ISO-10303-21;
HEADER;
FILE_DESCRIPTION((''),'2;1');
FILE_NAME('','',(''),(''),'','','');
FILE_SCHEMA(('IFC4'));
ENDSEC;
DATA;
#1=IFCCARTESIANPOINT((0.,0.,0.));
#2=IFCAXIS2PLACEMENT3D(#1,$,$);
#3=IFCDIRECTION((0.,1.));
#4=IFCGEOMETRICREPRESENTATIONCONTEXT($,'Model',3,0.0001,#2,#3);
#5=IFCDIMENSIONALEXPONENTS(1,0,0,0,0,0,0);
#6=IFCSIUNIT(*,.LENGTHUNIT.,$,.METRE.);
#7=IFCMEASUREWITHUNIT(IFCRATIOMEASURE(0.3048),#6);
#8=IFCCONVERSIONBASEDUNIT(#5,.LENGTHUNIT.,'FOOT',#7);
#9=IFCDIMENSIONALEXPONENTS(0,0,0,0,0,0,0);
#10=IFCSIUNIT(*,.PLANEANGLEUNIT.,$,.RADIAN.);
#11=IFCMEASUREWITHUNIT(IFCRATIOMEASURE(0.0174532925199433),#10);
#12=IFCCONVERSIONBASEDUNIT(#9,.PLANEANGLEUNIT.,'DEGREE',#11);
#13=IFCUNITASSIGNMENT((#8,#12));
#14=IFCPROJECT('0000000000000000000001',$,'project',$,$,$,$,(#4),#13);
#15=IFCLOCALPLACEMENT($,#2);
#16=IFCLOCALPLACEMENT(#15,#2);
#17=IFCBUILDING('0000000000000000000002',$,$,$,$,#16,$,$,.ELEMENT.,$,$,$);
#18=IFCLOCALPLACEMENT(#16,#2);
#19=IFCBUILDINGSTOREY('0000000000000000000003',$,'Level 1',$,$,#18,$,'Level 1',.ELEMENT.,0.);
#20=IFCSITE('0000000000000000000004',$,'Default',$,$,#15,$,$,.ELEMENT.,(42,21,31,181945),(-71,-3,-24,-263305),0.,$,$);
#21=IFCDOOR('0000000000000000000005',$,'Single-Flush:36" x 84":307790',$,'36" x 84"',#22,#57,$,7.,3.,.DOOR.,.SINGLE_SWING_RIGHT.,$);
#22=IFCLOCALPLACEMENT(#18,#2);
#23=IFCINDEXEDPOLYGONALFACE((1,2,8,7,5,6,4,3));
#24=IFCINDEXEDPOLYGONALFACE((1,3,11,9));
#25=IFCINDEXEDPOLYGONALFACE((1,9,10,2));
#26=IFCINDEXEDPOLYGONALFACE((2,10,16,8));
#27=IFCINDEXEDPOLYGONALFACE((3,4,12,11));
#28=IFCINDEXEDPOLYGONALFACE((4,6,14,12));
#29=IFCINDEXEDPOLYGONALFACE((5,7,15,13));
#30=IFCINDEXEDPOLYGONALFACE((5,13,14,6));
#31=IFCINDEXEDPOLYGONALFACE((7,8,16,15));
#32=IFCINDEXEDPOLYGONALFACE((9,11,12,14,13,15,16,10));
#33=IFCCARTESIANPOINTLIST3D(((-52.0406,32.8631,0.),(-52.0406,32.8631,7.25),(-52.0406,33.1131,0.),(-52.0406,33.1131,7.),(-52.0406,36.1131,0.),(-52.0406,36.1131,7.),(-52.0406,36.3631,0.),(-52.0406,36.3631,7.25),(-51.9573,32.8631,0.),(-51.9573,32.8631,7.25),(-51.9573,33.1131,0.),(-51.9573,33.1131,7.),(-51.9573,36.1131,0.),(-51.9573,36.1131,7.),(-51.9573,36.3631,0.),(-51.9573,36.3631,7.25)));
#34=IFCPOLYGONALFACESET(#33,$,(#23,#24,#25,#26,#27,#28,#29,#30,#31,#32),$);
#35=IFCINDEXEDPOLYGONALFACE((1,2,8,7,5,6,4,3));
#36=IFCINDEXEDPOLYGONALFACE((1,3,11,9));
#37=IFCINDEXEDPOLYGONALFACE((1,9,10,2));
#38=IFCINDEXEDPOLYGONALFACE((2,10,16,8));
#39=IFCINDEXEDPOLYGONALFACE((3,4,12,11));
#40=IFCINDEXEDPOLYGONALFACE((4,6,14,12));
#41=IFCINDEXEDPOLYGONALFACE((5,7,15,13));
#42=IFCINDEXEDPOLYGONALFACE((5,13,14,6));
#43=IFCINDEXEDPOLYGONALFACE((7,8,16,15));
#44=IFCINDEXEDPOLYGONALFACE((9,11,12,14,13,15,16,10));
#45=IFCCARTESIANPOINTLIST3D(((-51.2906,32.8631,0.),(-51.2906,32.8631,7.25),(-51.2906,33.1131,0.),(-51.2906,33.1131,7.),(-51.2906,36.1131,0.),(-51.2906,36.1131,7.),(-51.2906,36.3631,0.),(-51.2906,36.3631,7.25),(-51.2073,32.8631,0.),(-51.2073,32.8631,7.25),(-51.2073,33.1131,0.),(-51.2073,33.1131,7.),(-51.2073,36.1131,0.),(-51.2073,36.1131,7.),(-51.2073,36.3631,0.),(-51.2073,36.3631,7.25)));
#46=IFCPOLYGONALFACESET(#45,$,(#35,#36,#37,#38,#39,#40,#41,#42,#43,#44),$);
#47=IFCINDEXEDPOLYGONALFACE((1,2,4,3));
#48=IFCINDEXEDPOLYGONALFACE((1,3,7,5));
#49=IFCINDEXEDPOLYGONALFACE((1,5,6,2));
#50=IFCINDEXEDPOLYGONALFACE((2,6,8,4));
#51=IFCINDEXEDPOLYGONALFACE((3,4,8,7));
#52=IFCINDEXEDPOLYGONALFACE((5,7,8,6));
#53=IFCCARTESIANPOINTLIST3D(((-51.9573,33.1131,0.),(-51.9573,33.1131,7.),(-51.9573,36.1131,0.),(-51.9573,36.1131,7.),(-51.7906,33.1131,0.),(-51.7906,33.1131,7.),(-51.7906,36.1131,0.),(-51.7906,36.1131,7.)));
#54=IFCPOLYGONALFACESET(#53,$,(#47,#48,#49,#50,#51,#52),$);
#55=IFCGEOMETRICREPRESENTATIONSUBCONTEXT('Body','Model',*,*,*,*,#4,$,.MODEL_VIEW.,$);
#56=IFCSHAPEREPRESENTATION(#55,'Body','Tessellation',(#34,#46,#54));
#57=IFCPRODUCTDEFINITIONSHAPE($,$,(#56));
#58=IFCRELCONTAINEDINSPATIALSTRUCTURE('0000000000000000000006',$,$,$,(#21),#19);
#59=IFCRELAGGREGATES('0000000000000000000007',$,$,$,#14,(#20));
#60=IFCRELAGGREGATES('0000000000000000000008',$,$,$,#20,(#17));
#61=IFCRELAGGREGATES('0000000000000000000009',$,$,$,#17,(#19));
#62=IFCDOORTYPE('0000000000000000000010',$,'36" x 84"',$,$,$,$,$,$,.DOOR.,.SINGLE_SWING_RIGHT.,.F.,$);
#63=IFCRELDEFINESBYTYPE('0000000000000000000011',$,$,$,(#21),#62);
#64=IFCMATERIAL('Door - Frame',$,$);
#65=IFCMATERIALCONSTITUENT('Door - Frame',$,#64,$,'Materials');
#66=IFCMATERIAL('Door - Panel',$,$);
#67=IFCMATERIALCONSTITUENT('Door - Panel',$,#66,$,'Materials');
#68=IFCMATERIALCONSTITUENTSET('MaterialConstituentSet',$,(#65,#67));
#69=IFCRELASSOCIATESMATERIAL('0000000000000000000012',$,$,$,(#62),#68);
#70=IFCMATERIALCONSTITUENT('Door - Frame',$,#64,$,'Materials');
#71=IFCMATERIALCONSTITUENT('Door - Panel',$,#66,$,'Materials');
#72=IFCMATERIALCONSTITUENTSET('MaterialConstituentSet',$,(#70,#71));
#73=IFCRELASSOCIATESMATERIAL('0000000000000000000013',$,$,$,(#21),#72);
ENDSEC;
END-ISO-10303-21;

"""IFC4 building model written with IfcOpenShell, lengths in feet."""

from ifc_helpers import new_model, entity, si_unit, converted_unit, direction, frame, frame_2d, origin, place, context, subcontext, project, spatial, polyline, rectangle, outline, extrude, source, transform, mapped, material, constituent, constituent_set, type_object, type_shapes, element, save


model = new_model("IFC4")

# Units and contexts
model_context = context("Model", 3, precision=0.0001, world=origin(), true_north=direction((0.0, 1.0)))
body_context = subcontext(model_context, "Body", "Model", "MODEL_VIEW")
ifc_project = project(units=[converted_unit("LENGTHUNIT", "FOOT", entity("IfcRatioMeasure", 0.3048), si_unit("LENGTHUNIT", "METRE"), dimensions=[1, 0, 0, 0, 0, 0, 0]), converted_unit("PLANEANGLEUNIT", "DEGREE", entity("IfcRatioMeasure", 0.0174532925199433), si_unit("PLANEANGLEUNIT", "RADIAN"), dimensions=[0, 0, 0, 0, 0, 0, 0])], contexts=[model_context])

# Site, building, storey
site_placement = place(None, origin())
site = spatial("IfcSite", under=ifc_project, at=site_placement, Name="Default", CompositionType="ELEMENT", RefLatitude=(42, 21, 31, 181945), RefLongitude=(-71, -3, -24, -263305), RefElevation=0.0)
building_placement = place(site_placement, origin())
building = spatial("IfcBuilding", under=site, at=building_placement, CompositionType="ELEMENT")
storey_placement = place(building_placement, origin())
storey = spatial("IfcBuildingStorey", under=building, at=storey_placement, Name="Level 1", LongName="Level 1", CompositionType="ELEMENT", Elevation=0.0)

# Shared definitions
placement_1 = place(storey_placement, frame((-51.6239, 66.9464, 0.0), z_axis=(0.0, 0.0, 1.0), x_axis=(0.0, -1.0, 0.0)))

# Door
ifc_material_1 = material(Name="Door - Frame")
ifc_constituent_1 = constituent(ifc_material_1, Name="Door - Frame", Category="Materials")
ifc_material_2 = material(Name="Door - Panel")
ifc_constituent_2 = constituent(ifc_material_2, Name="Door - Panel", Category="Materials")
ifc_constituent_set_1 = constituent_set(constituents=[ifc_constituent_1, ifc_constituent_2], Name="MaterialConstituentSet")
ifc_constituent_3 = constituent(ifc_material_1, Name="Door - Frame", Category="Materials")
ifc_constituent_4 = constituent(ifc_material_2, Name="Door - Panel", Category="Materials")
ifc_constituent_set_2 = constituent_set(constituents=[ifc_constituent_3, ifc_constituent_4], Name="MaterialConstituentSet")
door_type = type_object("IfcDoorType", Name="36\" x 84\"", OperationType="SINGLE_SWING_RIGHT", ParameterTakesPrecedence=False, PredefinedType="DOOR", material=ifc_constituent_set_2)
shared_shape = source(origin(), body_context, "Body", "SweptSolid", [
    extrude(outline(polyline([(-1.75, -3.6875), (1.75, -3.6875), (1.75, 3.5625), (1.5, 3.5625), (1.5, -3.4375), (-1.5, -3.4375), (-1.5, 3.5625), (-1.75, 3.5625), (-1.75, -3.6875)])), frame((1.5, 0.6667, 3.5625), z_axis=(0.0, 1.0, 0.0), x_axis=(1.0, 0.0, 0.0)), (0.0, 0.0, 1.0), 0.0833),
    extrude(outline(polyline([(-3.6875, -1.75), (3.5625, -1.75), (3.5625, -1.5), (-3.4375, -1.5), (-3.4375, 1.5), (3.5625, 1.5), (3.5625, 1.75), (-3.6875, 1.75), (-3.6875, -1.75)])), frame((1.5, -0.0833, 3.5625), z_axis=(0.0, 1.0, 0.0), x_axis=(0.0, 0.0, -1.0)), (0.0, 0.0, 1.0), 0.0833),
    extrude(rectangle(XDim=0.1667, YDim=3.0, at=frame_2d((0.0, 0.0), x_axis=(1.0, 0.0))), frame((1.5, 0.5833, 0.0), z_axis=(0.0, 0.0, 1.0), x_axis=(0.0, 1.0, 0.0)), (0.0, 0.0, 1.0), 7.0),
])
type_shapes(door_type, [shared_shape])
placement_2 = place(placement_1, frame((33.8333, 0.3333, 0.0)))
door_placement = place(placement_2, frame((0.0, 0.0, 0.0), z_axis=(0.0, 0.0, 1.0), x_axis=(-1.0, 0.0, 0.0)))
element("IfcDoor", 1, at=door_placement, inside=storey, type_object=door_type, material=ifc_constituent_set_1, Name="Single-Flush:36\" x 84\":307790", ObjectType="36\" x 84\"", OperationType="SINGLE_SWING_RIGHT", OverallHeight=7.0, OverallWidth=3.0, PredefinedType="DOOR", context=body_context, shape_type="MappedRepresentation", body=[
    mapped(shared_shape, transform((0.0, 0.0, 0.0), scale=1.0)),
])

save(model, "model.ifc")
